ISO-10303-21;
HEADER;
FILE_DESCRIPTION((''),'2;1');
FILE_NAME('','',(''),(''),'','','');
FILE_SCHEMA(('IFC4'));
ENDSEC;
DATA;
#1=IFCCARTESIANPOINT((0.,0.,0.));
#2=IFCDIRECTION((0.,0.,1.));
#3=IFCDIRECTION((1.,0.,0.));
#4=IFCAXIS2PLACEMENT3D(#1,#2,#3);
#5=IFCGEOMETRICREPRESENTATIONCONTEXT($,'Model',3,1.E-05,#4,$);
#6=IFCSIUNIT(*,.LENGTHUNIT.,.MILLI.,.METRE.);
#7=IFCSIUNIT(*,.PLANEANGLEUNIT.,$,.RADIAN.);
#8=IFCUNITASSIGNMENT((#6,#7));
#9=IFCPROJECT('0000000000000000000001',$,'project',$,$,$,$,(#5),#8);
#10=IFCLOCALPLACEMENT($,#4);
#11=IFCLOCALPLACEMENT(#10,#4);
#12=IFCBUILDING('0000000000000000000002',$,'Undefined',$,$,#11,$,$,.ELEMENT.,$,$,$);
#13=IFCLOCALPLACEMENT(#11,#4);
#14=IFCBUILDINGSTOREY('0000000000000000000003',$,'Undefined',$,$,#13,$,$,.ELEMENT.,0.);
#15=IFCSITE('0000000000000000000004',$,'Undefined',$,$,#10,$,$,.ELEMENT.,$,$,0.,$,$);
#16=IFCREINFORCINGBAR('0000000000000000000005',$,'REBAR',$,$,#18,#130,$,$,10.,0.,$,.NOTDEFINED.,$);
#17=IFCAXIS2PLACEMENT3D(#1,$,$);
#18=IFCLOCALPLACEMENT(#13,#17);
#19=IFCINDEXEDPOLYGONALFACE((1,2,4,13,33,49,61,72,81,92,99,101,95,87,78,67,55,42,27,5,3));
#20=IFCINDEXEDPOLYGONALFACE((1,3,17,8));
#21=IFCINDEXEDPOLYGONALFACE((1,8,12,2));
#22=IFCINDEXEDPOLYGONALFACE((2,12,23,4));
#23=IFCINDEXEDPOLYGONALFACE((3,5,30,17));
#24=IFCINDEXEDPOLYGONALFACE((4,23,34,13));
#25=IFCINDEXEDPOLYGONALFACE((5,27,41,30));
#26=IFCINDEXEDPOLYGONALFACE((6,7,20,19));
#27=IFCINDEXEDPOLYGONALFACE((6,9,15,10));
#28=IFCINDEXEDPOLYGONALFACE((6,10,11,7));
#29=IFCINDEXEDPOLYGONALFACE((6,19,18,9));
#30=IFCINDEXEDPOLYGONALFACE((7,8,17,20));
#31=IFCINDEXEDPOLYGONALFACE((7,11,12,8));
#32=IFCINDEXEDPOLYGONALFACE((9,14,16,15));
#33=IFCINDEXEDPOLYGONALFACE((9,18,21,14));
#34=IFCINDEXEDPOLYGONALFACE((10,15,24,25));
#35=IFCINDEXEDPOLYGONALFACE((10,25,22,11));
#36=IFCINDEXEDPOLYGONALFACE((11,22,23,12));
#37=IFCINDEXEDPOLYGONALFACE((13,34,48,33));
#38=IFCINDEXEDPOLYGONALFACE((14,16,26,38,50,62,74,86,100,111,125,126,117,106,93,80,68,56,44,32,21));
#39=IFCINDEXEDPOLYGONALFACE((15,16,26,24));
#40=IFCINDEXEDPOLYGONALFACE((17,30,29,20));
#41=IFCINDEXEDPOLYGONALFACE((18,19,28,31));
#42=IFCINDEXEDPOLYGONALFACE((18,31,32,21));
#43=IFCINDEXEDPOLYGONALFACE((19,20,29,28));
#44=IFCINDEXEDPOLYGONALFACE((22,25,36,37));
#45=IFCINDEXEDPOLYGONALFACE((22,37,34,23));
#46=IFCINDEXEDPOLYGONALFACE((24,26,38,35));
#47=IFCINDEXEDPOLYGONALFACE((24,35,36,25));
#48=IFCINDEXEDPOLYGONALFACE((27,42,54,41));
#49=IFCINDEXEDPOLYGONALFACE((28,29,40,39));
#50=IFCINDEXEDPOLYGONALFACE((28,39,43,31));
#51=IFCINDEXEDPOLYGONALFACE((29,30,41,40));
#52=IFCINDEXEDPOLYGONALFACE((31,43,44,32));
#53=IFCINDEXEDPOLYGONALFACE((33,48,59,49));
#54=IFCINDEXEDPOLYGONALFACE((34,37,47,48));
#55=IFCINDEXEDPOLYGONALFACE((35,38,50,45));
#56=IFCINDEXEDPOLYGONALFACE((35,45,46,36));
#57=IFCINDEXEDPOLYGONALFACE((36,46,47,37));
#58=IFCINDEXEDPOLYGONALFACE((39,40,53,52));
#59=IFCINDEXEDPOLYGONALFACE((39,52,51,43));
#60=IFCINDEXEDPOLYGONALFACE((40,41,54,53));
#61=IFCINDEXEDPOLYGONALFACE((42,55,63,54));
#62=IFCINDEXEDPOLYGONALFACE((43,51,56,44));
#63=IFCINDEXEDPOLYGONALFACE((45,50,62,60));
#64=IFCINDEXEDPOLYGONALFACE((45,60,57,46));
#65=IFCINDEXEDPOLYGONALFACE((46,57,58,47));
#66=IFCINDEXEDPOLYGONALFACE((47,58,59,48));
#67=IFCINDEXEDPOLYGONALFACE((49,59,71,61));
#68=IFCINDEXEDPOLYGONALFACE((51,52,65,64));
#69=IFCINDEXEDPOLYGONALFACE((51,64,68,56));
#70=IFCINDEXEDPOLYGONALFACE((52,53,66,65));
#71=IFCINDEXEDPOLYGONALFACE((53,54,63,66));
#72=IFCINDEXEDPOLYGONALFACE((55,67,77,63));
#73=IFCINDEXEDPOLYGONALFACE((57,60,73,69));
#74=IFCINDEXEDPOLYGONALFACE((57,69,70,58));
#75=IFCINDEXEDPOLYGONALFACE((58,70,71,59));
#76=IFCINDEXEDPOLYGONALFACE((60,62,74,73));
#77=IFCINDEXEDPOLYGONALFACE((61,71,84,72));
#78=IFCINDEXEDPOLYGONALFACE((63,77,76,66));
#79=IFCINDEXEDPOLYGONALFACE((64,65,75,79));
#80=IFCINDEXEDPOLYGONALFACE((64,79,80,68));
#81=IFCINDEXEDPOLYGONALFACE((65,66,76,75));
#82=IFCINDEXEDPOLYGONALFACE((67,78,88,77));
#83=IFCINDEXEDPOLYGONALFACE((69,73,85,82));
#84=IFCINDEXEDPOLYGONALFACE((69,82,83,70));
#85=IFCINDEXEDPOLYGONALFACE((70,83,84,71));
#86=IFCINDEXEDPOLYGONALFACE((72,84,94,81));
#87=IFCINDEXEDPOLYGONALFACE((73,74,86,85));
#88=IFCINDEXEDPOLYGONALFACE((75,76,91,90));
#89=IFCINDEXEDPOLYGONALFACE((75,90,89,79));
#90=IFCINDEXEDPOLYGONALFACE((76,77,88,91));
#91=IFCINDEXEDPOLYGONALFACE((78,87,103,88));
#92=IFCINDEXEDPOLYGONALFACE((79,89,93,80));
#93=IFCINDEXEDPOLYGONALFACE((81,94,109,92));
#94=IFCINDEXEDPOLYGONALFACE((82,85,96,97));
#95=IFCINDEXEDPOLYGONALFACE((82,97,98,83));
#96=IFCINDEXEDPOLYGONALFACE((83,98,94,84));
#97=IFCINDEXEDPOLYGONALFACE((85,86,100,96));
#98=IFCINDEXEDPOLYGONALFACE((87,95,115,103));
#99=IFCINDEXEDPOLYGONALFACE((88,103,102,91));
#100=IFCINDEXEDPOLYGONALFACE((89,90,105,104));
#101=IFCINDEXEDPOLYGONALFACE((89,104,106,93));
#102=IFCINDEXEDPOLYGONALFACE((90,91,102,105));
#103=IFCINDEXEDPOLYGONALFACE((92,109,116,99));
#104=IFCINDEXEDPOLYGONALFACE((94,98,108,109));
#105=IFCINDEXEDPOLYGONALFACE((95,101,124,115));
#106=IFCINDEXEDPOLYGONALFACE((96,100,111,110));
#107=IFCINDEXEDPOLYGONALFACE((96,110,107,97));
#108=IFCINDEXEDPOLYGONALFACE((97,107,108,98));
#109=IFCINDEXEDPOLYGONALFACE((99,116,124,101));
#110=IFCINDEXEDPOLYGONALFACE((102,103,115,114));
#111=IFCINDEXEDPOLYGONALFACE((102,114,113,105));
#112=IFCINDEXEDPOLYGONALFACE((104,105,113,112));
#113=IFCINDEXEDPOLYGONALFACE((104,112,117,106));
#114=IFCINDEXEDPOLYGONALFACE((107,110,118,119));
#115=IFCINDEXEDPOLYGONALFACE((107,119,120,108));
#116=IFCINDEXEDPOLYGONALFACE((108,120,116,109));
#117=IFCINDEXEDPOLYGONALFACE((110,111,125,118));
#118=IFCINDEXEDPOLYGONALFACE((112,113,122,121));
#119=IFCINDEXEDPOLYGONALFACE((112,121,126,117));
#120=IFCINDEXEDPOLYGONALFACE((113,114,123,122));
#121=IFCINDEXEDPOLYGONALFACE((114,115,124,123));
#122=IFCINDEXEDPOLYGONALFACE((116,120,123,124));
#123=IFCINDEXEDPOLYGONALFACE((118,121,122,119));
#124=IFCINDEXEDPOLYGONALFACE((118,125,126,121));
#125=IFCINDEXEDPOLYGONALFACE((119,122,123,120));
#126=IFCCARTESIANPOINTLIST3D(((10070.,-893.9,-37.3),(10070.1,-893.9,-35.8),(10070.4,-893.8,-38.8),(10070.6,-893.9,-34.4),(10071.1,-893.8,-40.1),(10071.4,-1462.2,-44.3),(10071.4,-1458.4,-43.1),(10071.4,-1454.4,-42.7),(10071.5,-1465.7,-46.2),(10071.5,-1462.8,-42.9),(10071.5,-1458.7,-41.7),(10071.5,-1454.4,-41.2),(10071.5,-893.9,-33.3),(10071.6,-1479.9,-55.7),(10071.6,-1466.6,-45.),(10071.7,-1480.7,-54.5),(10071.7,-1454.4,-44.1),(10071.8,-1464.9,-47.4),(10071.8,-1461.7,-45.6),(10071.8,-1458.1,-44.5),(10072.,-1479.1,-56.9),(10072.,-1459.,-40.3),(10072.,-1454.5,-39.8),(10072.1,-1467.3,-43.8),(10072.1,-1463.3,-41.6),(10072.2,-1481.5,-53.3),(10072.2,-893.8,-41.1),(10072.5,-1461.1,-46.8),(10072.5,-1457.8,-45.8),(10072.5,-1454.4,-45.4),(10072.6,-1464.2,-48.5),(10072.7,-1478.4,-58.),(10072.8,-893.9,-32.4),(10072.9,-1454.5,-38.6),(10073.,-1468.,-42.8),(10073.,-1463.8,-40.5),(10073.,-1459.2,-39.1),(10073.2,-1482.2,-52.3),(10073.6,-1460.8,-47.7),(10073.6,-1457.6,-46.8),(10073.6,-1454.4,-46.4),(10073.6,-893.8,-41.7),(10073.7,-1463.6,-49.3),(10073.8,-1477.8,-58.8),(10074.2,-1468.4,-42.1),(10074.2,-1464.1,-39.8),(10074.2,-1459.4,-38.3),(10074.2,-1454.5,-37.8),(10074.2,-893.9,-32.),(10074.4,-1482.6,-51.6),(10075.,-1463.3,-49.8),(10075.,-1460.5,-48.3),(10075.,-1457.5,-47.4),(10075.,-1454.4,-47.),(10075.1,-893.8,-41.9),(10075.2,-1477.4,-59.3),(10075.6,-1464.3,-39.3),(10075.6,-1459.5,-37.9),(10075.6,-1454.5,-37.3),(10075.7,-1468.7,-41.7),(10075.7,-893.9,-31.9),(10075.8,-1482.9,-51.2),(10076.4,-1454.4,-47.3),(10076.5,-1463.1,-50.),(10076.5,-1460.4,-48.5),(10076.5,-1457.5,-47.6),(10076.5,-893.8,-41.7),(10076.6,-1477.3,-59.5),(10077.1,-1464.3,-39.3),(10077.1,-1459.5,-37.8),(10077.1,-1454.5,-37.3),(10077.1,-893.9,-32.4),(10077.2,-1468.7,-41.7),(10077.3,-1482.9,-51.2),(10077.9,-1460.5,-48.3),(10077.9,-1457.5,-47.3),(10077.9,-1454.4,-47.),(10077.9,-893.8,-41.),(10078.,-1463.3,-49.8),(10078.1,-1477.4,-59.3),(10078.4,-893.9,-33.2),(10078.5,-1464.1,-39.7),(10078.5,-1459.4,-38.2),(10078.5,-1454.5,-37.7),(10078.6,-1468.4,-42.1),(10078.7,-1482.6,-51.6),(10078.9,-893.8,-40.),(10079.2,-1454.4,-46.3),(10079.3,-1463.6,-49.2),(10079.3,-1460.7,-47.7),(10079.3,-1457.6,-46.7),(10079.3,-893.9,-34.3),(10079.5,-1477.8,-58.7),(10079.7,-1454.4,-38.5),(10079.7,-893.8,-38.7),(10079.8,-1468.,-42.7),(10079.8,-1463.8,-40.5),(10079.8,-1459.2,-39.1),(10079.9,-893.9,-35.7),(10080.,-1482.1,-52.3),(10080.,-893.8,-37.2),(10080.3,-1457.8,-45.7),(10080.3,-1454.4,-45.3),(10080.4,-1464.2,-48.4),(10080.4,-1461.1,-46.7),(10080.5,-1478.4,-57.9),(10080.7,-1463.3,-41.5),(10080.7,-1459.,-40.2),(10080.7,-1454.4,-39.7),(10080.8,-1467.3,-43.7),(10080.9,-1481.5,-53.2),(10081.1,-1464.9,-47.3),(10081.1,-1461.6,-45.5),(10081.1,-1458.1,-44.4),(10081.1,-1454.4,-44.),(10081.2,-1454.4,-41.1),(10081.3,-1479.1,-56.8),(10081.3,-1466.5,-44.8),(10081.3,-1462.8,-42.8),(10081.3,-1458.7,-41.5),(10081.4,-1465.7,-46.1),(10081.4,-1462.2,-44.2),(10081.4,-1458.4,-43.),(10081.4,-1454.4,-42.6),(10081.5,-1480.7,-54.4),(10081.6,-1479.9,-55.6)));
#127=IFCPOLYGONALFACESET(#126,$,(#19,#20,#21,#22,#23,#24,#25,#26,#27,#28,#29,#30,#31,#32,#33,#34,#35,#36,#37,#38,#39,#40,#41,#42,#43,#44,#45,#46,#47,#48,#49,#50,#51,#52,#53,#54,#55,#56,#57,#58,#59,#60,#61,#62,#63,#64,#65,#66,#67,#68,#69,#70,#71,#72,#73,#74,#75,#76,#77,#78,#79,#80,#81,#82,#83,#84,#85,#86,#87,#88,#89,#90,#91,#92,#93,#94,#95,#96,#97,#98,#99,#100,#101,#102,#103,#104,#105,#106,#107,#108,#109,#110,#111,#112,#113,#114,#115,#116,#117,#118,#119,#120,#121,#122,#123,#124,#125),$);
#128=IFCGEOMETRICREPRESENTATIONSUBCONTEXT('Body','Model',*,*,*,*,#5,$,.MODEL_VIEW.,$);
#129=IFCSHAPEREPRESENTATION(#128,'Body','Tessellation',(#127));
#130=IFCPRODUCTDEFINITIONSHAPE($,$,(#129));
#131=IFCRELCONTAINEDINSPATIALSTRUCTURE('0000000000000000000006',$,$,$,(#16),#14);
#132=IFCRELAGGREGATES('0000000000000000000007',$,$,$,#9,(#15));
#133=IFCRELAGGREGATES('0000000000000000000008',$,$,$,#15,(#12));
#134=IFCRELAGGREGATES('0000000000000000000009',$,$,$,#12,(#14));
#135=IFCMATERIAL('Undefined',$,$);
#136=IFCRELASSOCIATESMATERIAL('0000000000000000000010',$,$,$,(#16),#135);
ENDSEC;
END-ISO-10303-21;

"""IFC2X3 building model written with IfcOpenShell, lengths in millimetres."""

from ifc_helpers import new_model, entity, si_unit, frame, origin_with_axes, place, context, subcontext, project, spatial, source, transform, mapped, material, element, save


model = new_model("IFC2X3")

# Units and contexts
model_context = context("Model", 3, precision=1e-05, world=origin_with_axes())
body_context = subcontext(model_context, "Body", "Model", "MODEL_VIEW")
ifc_project = project(units=[si_unit("LENGTHUNIT", "METRE", prefix="MILLI"), si_unit("PLANEANGLEUNIT", "RADIAN")], contexts=[model_context])

# Site, building, storey
site_placement = place(None, origin_with_axes())
site = spatial("IfcSite", under=ifc_project, at=site_placement, Name="Undefined", CompositionType="ELEMENT", RefElevation=0.0)
building_placement = place(site_placement, origin_with_axes())
building = spatial("IfcBuilding", under=site, at=building_placement, Name="Undefined", CompositionType="ELEMENT")
storey_placement = place(building_placement, origin_with_axes())
storey = spatial("IfcBuildingStorey", under=building, at=storey_placement, Name="Undefined", CompositionType="ELEMENT", Elevation=0.0)

# Reinforcing bar
ifc_material_1 = material(Name="Undefined")
shared_shape_1 = source(origin_with_axes(), body_context, "Body", "AdvancedSweptSolid", [
    entity("IfcSweptDiskSolid", entity("IfcCompositeCurve", [entity("IfcCompositeCurveSegment", "CONTINUOUS", True, entity("IfcTrimmedCurve", entity("IfcLine", entity("IfcCartesianPoint", [0.0, 0.0, 0.0]), entity("IfcVector", entity("IfcDirection", [0.835483, 0.0, -0.549516]), 1.0)), [entity("IfcParameterValue", 0.0)], [entity("IfcParameterValue", 17.082101)], True, "PARAMETER")), entity("IfcCompositeCurveSegment", "CONTINUOUS", True, entity("IfcTrimmedCurve", entity("IfcCircle", entity("IfcAxis2Placement3D", entity("IfcCartesianPoint", [25.8, 0.0, 8.2]), entity("IfcDirection", [0.0, -1.0, 0.0]), entity("IfcDirection", [-0.549516, 0.0, -0.835483])), 21.0), [entity("IfcParameterValue", 0.0)], [entity("IfcParameterValue", 0.581785)], True, "PARAMETER")), entity("IfcCompositeCurveSegment", "DISCONTINUOUS", True, entity("IfcTrimmedCurve", entity("IfcLine", entity("IfcCartesianPoint", [25.8, 0.0, -12.8]), entity("IfcVector", entity("IfcDirection", [1.0, 0.0, 0.0]), 1.0)), [entity("IfcParameterValue", 0.0)], [entity("IfcParameterValue", 560.593055)], True, "PARAMETER"))], False), 5.0, None, 0.0, 578.3),
])
reinforcing_bar_1_placement = place(storey_placement, frame((10076.5, -1471.5, -44.9), z_axis=(0.012204, 0.009592, -0.99988), x_axis=(-0.002468, 0.999951, 0.009562)))
element("IfcReinforcingBar", 1, at=reinforcing_bar_1_placement, inside=storey, material=ifc_material_1, Name="REBAR", BarRole="NOTDEFINED", CrossSectionArea=0.0, NominalDiameter=10.0, context=body_context, shape_type="MappedRepresentation", body=[
    mapped(shared_shape_1, transform((-8.7, 0.0, 10.3))),
])

save(model, "model.ifc")
